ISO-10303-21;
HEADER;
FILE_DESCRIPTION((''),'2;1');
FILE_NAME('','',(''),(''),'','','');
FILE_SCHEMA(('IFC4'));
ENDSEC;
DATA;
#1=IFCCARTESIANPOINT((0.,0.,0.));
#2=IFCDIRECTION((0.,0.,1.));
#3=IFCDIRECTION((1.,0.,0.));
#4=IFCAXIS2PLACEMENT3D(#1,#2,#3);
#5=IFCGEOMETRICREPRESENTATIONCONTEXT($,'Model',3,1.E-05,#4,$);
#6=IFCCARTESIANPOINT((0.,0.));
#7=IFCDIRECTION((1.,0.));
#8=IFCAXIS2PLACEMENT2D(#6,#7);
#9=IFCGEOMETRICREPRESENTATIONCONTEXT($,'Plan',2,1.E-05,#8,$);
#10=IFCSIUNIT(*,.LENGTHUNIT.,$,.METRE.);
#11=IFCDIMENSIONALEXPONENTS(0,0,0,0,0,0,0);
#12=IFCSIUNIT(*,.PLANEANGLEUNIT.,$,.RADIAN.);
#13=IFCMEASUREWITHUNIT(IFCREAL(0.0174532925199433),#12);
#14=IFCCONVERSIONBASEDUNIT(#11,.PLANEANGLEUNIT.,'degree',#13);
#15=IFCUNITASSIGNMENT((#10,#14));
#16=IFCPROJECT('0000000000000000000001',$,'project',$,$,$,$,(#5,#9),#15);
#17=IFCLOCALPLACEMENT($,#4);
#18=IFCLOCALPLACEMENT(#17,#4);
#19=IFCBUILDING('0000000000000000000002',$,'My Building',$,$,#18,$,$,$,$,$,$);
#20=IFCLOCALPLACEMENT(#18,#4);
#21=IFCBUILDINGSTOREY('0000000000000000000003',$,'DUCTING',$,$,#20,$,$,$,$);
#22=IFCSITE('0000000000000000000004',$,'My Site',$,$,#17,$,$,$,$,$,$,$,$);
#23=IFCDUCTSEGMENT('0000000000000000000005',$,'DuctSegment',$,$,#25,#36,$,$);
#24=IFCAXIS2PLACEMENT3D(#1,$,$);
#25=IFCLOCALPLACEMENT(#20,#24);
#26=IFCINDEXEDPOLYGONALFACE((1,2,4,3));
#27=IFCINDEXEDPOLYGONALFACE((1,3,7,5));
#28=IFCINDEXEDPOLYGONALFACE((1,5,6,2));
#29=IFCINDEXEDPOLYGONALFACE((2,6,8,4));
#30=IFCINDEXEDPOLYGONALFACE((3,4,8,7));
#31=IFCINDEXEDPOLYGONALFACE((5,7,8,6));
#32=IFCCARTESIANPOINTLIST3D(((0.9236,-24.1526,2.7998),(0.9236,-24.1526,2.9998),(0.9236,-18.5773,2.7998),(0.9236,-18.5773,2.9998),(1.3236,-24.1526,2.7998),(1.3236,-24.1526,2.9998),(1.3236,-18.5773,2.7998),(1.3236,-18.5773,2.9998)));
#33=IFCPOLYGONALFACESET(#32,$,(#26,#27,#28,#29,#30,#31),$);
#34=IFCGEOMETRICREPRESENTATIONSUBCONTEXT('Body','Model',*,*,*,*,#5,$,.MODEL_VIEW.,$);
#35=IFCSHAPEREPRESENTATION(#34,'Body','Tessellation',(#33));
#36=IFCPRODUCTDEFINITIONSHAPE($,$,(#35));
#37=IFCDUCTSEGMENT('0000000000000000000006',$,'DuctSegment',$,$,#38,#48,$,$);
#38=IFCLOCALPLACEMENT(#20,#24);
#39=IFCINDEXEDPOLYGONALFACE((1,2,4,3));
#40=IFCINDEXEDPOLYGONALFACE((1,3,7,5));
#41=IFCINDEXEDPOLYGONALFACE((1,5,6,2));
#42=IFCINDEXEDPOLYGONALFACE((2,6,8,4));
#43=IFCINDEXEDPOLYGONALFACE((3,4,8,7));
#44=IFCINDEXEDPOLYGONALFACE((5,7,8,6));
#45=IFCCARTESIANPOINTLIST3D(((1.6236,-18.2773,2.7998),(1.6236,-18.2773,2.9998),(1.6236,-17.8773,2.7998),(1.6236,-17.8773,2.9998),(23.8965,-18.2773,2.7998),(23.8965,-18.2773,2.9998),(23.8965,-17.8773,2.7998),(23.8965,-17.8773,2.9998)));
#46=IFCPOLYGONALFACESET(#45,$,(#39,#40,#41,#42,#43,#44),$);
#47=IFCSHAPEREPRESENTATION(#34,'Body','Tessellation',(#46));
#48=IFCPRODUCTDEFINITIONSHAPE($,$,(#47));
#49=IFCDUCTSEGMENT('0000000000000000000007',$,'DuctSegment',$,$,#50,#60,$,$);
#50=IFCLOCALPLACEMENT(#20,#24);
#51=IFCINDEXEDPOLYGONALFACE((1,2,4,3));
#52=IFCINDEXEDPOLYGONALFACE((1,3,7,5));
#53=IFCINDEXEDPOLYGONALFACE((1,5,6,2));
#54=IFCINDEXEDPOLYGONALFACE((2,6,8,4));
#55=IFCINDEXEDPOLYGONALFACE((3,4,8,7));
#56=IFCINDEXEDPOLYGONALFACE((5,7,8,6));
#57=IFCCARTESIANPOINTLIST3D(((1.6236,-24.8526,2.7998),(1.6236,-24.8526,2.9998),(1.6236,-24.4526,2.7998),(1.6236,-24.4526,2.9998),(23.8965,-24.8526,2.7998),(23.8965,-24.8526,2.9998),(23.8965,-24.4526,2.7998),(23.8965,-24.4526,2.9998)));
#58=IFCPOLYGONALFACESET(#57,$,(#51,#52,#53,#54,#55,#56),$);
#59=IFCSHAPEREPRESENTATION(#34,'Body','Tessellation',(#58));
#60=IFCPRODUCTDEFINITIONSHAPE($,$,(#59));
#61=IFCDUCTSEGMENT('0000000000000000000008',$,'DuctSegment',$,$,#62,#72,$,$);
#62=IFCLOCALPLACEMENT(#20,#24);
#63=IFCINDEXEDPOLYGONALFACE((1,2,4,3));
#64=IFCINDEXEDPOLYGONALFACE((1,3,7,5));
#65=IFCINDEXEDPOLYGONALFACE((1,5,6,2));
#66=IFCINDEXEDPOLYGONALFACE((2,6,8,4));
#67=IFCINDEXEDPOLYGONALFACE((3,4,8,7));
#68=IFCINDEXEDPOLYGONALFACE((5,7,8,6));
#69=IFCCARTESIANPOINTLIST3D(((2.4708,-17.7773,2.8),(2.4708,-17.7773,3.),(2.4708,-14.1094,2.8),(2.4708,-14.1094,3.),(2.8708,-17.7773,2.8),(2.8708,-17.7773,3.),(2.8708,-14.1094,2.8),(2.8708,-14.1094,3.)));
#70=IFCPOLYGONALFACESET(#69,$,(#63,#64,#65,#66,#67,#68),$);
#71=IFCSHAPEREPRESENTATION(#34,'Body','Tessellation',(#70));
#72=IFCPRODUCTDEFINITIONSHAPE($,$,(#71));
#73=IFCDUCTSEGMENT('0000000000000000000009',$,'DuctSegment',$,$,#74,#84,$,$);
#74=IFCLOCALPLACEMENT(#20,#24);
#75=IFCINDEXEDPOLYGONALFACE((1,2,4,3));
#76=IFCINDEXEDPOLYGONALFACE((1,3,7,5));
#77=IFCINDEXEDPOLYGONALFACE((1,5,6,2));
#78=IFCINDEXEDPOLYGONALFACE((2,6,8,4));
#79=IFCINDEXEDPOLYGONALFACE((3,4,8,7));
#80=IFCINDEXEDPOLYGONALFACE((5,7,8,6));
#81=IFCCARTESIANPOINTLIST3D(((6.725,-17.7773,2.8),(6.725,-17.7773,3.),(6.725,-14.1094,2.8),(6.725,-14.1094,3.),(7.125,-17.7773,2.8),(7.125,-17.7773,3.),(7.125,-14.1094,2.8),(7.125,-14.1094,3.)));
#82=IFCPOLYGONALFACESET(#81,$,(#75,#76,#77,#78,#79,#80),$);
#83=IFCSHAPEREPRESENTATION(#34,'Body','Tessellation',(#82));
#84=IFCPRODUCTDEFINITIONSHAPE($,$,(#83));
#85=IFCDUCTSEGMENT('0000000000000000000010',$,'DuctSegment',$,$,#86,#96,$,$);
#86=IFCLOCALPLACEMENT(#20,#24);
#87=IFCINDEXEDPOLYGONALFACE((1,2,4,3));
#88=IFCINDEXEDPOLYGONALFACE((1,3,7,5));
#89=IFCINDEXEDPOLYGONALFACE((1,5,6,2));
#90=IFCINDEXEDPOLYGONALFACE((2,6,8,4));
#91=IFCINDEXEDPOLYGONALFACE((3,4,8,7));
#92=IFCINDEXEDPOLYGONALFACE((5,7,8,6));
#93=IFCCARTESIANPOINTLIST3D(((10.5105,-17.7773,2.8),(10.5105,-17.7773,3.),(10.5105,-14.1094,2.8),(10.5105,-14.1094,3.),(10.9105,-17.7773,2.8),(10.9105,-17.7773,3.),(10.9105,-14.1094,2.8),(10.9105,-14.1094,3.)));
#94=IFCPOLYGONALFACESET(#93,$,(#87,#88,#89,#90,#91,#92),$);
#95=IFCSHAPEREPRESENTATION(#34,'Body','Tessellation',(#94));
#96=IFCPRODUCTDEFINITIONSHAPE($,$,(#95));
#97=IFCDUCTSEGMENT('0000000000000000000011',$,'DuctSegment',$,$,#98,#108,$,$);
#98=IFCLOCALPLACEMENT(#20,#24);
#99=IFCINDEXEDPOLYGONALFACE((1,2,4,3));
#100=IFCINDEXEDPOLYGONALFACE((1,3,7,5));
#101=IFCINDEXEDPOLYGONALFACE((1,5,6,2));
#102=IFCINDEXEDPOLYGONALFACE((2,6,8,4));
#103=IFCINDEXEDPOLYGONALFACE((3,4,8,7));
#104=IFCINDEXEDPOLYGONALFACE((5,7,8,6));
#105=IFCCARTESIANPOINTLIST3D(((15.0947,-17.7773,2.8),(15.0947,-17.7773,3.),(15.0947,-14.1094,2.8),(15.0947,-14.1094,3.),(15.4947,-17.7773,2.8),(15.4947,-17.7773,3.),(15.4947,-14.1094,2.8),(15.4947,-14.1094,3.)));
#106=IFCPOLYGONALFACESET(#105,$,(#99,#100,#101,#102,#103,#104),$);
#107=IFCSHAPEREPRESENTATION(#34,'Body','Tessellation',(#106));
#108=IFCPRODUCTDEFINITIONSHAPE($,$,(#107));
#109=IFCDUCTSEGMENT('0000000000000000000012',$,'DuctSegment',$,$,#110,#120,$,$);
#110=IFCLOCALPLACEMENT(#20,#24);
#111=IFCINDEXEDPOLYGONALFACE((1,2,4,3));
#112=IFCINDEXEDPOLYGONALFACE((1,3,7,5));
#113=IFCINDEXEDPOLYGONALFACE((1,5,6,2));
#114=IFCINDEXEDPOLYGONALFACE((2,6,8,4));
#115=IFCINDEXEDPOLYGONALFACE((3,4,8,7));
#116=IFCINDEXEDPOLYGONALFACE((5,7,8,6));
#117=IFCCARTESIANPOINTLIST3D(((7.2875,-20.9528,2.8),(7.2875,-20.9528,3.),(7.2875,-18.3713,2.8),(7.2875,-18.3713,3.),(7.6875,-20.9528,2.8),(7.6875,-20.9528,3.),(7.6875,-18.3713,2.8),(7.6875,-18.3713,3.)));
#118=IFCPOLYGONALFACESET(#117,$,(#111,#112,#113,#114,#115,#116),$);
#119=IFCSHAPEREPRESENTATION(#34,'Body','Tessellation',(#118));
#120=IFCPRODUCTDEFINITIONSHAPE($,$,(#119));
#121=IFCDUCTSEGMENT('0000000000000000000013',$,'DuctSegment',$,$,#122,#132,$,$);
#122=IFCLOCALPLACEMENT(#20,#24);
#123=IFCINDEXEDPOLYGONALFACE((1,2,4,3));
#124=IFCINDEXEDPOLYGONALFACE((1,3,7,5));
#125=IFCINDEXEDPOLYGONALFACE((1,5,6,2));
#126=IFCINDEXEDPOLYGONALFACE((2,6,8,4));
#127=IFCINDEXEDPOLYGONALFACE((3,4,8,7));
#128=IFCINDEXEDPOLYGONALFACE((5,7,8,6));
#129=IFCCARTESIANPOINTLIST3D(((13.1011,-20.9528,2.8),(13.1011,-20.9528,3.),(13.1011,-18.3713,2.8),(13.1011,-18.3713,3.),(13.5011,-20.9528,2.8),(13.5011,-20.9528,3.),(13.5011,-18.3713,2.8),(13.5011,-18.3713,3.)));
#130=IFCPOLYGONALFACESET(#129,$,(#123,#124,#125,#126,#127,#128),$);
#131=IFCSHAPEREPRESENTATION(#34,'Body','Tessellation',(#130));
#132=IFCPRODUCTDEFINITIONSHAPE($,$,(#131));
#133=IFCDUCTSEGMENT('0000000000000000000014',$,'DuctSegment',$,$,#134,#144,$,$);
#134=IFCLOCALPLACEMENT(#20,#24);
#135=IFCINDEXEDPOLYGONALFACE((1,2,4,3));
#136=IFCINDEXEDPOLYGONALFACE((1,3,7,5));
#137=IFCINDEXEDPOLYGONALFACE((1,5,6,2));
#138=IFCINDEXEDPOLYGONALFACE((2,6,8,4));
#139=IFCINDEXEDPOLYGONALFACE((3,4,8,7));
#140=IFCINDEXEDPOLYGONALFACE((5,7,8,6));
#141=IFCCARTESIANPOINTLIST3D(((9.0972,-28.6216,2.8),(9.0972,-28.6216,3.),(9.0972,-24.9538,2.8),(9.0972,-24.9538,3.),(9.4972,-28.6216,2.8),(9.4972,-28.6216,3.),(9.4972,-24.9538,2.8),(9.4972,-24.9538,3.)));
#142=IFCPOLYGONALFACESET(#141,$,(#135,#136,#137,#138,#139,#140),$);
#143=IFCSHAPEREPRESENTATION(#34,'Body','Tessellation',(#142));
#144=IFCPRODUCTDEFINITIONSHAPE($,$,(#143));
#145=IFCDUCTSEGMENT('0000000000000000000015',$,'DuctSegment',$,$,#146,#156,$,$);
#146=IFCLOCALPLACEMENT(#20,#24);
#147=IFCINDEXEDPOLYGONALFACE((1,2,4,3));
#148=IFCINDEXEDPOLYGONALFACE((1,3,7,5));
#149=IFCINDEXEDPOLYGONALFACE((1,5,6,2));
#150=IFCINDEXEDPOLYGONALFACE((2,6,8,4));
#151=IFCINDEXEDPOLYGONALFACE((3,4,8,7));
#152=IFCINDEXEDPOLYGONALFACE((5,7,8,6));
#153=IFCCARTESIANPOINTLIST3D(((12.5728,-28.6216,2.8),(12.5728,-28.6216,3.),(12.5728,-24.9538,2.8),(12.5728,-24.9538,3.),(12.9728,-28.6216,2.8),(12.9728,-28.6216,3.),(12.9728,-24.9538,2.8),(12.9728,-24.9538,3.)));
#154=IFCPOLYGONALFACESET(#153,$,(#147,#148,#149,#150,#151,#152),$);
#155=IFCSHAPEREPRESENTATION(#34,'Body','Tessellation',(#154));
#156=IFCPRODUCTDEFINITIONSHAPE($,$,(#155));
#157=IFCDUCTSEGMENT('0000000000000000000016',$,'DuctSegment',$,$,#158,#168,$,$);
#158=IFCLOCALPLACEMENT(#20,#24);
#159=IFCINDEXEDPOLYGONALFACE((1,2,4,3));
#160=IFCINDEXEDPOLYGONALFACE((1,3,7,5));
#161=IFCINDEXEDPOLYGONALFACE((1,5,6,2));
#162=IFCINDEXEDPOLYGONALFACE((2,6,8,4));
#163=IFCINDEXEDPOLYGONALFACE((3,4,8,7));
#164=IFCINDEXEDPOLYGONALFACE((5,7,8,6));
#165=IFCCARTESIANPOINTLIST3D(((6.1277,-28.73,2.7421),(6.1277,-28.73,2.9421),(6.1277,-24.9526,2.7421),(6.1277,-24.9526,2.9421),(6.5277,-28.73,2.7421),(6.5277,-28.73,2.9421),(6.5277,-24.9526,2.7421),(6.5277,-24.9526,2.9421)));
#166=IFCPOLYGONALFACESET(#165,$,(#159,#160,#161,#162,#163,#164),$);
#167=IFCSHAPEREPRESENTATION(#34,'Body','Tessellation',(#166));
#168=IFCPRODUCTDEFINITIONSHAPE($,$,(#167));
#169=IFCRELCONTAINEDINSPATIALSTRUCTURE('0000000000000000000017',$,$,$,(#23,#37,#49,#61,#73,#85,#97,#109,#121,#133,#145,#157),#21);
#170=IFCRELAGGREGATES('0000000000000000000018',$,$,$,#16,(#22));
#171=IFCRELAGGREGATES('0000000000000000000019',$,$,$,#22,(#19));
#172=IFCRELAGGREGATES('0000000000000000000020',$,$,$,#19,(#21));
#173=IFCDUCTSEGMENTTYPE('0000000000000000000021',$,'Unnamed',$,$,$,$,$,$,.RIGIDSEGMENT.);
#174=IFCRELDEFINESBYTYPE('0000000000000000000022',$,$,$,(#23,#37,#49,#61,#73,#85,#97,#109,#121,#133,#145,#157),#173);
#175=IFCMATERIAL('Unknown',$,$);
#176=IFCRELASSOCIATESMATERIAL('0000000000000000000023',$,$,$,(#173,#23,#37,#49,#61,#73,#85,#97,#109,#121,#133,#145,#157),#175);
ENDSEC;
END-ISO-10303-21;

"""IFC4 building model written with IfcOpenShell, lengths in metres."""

from ifc_helpers import new_model, entity, si_unit, converted_unit, frame, origin_with_axes, origin_2d_with_axis, place, context, subcontext, project, spatial, rectangle, extrude, material, material_profile, profile_set, profile_usage, type_object, element, save


model = new_model("IFC4")

# Units and contexts
model_context = context("Model", 3, precision=1e-05, world=origin_with_axes())
plan_context = context("Plan", 2, precision=1e-05, world=origin_2d_with_axis())
body_context = subcontext(model_context, "Body", "Model", "MODEL_VIEW")
ifc_project = project(units=[si_unit("LENGTHUNIT", "METRE"), converted_unit("PLANEANGLEUNIT", "degree", entity("IfcReal", 0.0174532925199433), si_unit("PLANEANGLEUNIT", "RADIAN"), dimensions=[0, 0, 0, 0, 0, 0, 0])], contexts=[model_context, plan_context])

# Site, building, storey
site_placement = place(None, origin_with_axes())
site = spatial("IfcSite", under=ifc_project, at=site_placement, Name="My Site")
building_placement = place(site_placement, origin_with_axes())
building = spatial("IfcBuilding", under=site, at=building_placement, Name="My Building")
storey_placement = place(building_placement, origin_with_axes())
storey = spatial("IfcBuildingStorey", under=building, at=storey_placement, Name="DUCTING")

# Duct segments
ifc_material = material(Name="Unknown")
ifc_material_profile_1 = material_profile(ifc_material, rectangle(XDim=0.4, YDim=0.2))
ifc_profile_set_1 = profile_set([ifc_material_profile_1])
ifc_profile_usage_1 = profile_usage(ifc_profile_set_1, cardinal=5)
duct_segment_type = type_object("IfcDuctSegmentType", Name="Unnamed", PredefinedType="RIGIDSEGMENT", material=ifc_profile_set_1)
duct_segment_1_placement = place(storey_placement, frame((1.1236, -18.5773, 2.8998), z_axis=(0.0, -1.0, 0.0), x_axis=(1.0, 0.0, 0.0)))
element("IfcDuctSegment", 1, at=duct_segment_1_placement, inside=storey, type_object=duct_segment_type, material=ifc_profile_usage_1, Name="DuctSegment", context=body_context, shape_type="SweptSolid", body=[
    extrude(rectangle(XDim=0.4, YDim=0.2), origin_with_axes(), (0.0, 0.0, 1.0), 5.5753),
])
ifc_profile_usage_2 = profile_usage(ifc_profile_set_1, cardinal=5)
duct_segment_2_placement = place(storey_placement, frame((1.6236, -18.0773, 2.8998), z_axis=(1.0, 0.0, 0.0), x_axis=(0.0, 1.0, 0.0)))
element("IfcDuctSegment", 2, at=duct_segment_2_placement, inside=storey, type_object=duct_segment_type, material=ifc_profile_usage_2, Name="DuctSegment", context=body_context, shape_type="SweptSolid", body=[
    extrude(rectangle(XDim=0.4, YDim=0.2), origin_with_axes(), (0.0, 0.0, 1.0), 22.2729),
])
ifc_profile_usage_3 = profile_usage(ifc_profile_set_1, cardinal=5)
duct_segment_3_placement = place(storey_placement, frame((1.6236, -24.6526, 2.8998), z_axis=(1.0, 0.0, 0.0), x_axis=(0.0, 1.0, 0.0)))
element("IfcDuctSegment", 3, at=duct_segment_3_placement, inside=storey, type_object=duct_segment_type, material=ifc_profile_usage_3, Name="DuctSegment", context=body_context, shape_type="SweptSolid", body=[
    extrude(rectangle(XDim=0.4, YDim=0.2), origin_with_axes(), (0.0, 0.0, 1.0), 22.2729),
])
ifc_profile_usage_4 = profile_usage(ifc_profile_set_1, cardinal=5)
duct_segment_4_placement = place(storey_placement, frame((2.6708, -17.7773, 2.9), z_axis=(0.0, 1.0, 0.0), x_axis=(-1.0, 0.0, 0.0)))
element("IfcDuctSegment", 4, at=duct_segment_4_placement, inside=storey, type_object=duct_segment_type, material=ifc_profile_usage_4, Name="DuctSegment", context=body_context, shape_type="SweptSolid", body=[
    extrude(rectangle(XDim=0.4, YDim=0.2), origin_with_axes(), (0.0, 0.0, 1.0), 3.6678),
])
ifc_profile_usage_5 = profile_usage(ifc_profile_set_1, cardinal=5)
duct_segment_5_placement = place(storey_placement, frame((6.925, -17.7773, 2.9), z_axis=(0.0, 1.0, 0.0), x_axis=(-1.0, 0.0, 0.0)))
element("IfcDuctSegment", 5, at=duct_segment_5_placement, inside=storey, type_object=duct_segment_type, material=ifc_profile_usage_5, Name="DuctSegment", context=body_context, shape_type="SweptSolid", body=[
    extrude(rectangle(XDim=0.4, YDim=0.2), origin_with_axes(), (0.0, 0.0, 1.0), 3.6678),
])
ifc_profile_usage_6 = profile_usage(ifc_profile_set_1, cardinal=5)
duct_segment_6_placement = place(storey_placement, frame((10.7105, -17.7773, 2.9), z_axis=(0.0, 1.0, 0.0), x_axis=(-1.0, 0.0, 0.0)))
element("IfcDuctSegment", 6, at=duct_segment_6_placement, inside=storey, type_object=duct_segment_type, material=ifc_profile_usage_6, Name="DuctSegment", context=body_context, shape_type="SweptSolid", body=[
    extrude(rectangle(XDim=0.4, YDim=0.2), origin_with_axes(), (0.0, 0.0, 1.0), 3.6678),
])
ifc_profile_usage_7 = profile_usage(ifc_profile_set_1, cardinal=5)
duct_segment_7_placement = place(storey_placement, frame((15.2947, -17.7773, 2.9), z_axis=(0.0, 1.0, 0.0), x_axis=(-1.0, 0.0, 0.0)))
element("IfcDuctSegment", 7, at=duct_segment_7_placement, inside=storey, type_object=duct_segment_type, material=ifc_profile_usage_7, Name="DuctSegment", context=body_context, shape_type="SweptSolid", body=[
    extrude(rectangle(XDim=0.4, YDim=0.2), origin_with_axes(), (0.0, 0.0, 1.0), 3.6678),
])
ifc_profile_usage_8 = profile_usage(ifc_profile_set_1, cardinal=5)
duct_segment_8_placement = place(storey_placement, frame((7.4875, -18.3713, 2.9), z_axis=(0.0, -1.0, 0.0), x_axis=(1.0, 0.0, 0.0)))
element("IfcDuctSegment", 8, at=duct_segment_8_placement, inside=storey, type_object=duct_segment_type, material=ifc_profile_usage_8, Name="DuctSegment", context=body_context, shape_type="SweptSolid", body=[
    extrude(rectangle(XDim=0.4, YDim=0.2), origin_with_axes(), (0.0, 0.0, 1.0), 2.5815),
])
ifc_profile_usage_9 = profile_usage(ifc_profile_set_1, cardinal=5)
duct_segment_9_placement = place(storey_placement, frame((13.3011, -18.3713, 2.9), z_axis=(0.0, -1.0, 0.0), x_axis=(1.0, 0.0, 0.0)))
element("IfcDuctSegment", 9, at=duct_segment_9_placement, inside=storey, type_object=duct_segment_type, material=ifc_profile_usage_9, Name="DuctSegment", context=body_context, shape_type="SweptSolid", body=[
    extrude(rectangle(XDim=0.4, YDim=0.2), origin_with_axes(), (0.0, 0.0, 1.0), 2.5815),
])
ifc_profile_usage_10 = profile_usage(ifc_profile_set_1, cardinal=5)
duct_segment_10_placement = place(storey_placement, frame((9.2972, -24.9538, 2.9), z_axis=(0.0, -1.0, 0.0), x_axis=(1.0, 0.0, 0.0)))
element("IfcDuctSegment", 10, at=duct_segment_10_placement, inside=storey, type_object=duct_segment_type, material=ifc_profile_usage_10, Name="DuctSegment", context=body_context, shape_type="SweptSolid", body=[
    extrude(rectangle(XDim=0.4, YDim=0.2), origin_with_axes(), (0.0, 0.0, 1.0), 3.6678),
])
ifc_profile_usage_11 = profile_usage(ifc_profile_set_1, cardinal=5)
duct_segment_11_placement = place(storey_placement, frame((12.7728, -24.9538, 2.9), z_axis=(0.0, -1.0, 0.0), x_axis=(1.0, 0.0, 0.0)))
element("IfcDuctSegment", 11, at=duct_segment_11_placement, inside=storey, type_object=duct_segment_type, material=ifc_profile_usage_11, Name="DuctSegment", context=body_context, shape_type="SweptSolid", body=[
    extrude(rectangle(XDim=0.4, YDim=0.2), origin_with_axes(), (0.0, 0.0, 1.0), 3.6678),
])
ifc_profile_usage_12 = profile_usage(ifc_profile_set_1, cardinal=5)
duct_segment_12_placement = place(storey_placement, frame((6.3277, -24.9526, 2.8421), z_axis=(0.0, -1.0, 0.0), x_axis=(1.0, 0.0, 0.0)))
element("IfcDuctSegment", 12, at=duct_segment_12_placement, inside=storey, type_object=duct_segment_type, material=ifc_profile_usage_12, Name="DuctSegment", context=body_context, shape_type="SweptSolid", body=[
    extrude(rectangle(XDim=0.4, YDim=0.2), origin_with_axes(), (0.0, 0.0, 1.0), 3.7774),
])

save(model, "model.ifc")
